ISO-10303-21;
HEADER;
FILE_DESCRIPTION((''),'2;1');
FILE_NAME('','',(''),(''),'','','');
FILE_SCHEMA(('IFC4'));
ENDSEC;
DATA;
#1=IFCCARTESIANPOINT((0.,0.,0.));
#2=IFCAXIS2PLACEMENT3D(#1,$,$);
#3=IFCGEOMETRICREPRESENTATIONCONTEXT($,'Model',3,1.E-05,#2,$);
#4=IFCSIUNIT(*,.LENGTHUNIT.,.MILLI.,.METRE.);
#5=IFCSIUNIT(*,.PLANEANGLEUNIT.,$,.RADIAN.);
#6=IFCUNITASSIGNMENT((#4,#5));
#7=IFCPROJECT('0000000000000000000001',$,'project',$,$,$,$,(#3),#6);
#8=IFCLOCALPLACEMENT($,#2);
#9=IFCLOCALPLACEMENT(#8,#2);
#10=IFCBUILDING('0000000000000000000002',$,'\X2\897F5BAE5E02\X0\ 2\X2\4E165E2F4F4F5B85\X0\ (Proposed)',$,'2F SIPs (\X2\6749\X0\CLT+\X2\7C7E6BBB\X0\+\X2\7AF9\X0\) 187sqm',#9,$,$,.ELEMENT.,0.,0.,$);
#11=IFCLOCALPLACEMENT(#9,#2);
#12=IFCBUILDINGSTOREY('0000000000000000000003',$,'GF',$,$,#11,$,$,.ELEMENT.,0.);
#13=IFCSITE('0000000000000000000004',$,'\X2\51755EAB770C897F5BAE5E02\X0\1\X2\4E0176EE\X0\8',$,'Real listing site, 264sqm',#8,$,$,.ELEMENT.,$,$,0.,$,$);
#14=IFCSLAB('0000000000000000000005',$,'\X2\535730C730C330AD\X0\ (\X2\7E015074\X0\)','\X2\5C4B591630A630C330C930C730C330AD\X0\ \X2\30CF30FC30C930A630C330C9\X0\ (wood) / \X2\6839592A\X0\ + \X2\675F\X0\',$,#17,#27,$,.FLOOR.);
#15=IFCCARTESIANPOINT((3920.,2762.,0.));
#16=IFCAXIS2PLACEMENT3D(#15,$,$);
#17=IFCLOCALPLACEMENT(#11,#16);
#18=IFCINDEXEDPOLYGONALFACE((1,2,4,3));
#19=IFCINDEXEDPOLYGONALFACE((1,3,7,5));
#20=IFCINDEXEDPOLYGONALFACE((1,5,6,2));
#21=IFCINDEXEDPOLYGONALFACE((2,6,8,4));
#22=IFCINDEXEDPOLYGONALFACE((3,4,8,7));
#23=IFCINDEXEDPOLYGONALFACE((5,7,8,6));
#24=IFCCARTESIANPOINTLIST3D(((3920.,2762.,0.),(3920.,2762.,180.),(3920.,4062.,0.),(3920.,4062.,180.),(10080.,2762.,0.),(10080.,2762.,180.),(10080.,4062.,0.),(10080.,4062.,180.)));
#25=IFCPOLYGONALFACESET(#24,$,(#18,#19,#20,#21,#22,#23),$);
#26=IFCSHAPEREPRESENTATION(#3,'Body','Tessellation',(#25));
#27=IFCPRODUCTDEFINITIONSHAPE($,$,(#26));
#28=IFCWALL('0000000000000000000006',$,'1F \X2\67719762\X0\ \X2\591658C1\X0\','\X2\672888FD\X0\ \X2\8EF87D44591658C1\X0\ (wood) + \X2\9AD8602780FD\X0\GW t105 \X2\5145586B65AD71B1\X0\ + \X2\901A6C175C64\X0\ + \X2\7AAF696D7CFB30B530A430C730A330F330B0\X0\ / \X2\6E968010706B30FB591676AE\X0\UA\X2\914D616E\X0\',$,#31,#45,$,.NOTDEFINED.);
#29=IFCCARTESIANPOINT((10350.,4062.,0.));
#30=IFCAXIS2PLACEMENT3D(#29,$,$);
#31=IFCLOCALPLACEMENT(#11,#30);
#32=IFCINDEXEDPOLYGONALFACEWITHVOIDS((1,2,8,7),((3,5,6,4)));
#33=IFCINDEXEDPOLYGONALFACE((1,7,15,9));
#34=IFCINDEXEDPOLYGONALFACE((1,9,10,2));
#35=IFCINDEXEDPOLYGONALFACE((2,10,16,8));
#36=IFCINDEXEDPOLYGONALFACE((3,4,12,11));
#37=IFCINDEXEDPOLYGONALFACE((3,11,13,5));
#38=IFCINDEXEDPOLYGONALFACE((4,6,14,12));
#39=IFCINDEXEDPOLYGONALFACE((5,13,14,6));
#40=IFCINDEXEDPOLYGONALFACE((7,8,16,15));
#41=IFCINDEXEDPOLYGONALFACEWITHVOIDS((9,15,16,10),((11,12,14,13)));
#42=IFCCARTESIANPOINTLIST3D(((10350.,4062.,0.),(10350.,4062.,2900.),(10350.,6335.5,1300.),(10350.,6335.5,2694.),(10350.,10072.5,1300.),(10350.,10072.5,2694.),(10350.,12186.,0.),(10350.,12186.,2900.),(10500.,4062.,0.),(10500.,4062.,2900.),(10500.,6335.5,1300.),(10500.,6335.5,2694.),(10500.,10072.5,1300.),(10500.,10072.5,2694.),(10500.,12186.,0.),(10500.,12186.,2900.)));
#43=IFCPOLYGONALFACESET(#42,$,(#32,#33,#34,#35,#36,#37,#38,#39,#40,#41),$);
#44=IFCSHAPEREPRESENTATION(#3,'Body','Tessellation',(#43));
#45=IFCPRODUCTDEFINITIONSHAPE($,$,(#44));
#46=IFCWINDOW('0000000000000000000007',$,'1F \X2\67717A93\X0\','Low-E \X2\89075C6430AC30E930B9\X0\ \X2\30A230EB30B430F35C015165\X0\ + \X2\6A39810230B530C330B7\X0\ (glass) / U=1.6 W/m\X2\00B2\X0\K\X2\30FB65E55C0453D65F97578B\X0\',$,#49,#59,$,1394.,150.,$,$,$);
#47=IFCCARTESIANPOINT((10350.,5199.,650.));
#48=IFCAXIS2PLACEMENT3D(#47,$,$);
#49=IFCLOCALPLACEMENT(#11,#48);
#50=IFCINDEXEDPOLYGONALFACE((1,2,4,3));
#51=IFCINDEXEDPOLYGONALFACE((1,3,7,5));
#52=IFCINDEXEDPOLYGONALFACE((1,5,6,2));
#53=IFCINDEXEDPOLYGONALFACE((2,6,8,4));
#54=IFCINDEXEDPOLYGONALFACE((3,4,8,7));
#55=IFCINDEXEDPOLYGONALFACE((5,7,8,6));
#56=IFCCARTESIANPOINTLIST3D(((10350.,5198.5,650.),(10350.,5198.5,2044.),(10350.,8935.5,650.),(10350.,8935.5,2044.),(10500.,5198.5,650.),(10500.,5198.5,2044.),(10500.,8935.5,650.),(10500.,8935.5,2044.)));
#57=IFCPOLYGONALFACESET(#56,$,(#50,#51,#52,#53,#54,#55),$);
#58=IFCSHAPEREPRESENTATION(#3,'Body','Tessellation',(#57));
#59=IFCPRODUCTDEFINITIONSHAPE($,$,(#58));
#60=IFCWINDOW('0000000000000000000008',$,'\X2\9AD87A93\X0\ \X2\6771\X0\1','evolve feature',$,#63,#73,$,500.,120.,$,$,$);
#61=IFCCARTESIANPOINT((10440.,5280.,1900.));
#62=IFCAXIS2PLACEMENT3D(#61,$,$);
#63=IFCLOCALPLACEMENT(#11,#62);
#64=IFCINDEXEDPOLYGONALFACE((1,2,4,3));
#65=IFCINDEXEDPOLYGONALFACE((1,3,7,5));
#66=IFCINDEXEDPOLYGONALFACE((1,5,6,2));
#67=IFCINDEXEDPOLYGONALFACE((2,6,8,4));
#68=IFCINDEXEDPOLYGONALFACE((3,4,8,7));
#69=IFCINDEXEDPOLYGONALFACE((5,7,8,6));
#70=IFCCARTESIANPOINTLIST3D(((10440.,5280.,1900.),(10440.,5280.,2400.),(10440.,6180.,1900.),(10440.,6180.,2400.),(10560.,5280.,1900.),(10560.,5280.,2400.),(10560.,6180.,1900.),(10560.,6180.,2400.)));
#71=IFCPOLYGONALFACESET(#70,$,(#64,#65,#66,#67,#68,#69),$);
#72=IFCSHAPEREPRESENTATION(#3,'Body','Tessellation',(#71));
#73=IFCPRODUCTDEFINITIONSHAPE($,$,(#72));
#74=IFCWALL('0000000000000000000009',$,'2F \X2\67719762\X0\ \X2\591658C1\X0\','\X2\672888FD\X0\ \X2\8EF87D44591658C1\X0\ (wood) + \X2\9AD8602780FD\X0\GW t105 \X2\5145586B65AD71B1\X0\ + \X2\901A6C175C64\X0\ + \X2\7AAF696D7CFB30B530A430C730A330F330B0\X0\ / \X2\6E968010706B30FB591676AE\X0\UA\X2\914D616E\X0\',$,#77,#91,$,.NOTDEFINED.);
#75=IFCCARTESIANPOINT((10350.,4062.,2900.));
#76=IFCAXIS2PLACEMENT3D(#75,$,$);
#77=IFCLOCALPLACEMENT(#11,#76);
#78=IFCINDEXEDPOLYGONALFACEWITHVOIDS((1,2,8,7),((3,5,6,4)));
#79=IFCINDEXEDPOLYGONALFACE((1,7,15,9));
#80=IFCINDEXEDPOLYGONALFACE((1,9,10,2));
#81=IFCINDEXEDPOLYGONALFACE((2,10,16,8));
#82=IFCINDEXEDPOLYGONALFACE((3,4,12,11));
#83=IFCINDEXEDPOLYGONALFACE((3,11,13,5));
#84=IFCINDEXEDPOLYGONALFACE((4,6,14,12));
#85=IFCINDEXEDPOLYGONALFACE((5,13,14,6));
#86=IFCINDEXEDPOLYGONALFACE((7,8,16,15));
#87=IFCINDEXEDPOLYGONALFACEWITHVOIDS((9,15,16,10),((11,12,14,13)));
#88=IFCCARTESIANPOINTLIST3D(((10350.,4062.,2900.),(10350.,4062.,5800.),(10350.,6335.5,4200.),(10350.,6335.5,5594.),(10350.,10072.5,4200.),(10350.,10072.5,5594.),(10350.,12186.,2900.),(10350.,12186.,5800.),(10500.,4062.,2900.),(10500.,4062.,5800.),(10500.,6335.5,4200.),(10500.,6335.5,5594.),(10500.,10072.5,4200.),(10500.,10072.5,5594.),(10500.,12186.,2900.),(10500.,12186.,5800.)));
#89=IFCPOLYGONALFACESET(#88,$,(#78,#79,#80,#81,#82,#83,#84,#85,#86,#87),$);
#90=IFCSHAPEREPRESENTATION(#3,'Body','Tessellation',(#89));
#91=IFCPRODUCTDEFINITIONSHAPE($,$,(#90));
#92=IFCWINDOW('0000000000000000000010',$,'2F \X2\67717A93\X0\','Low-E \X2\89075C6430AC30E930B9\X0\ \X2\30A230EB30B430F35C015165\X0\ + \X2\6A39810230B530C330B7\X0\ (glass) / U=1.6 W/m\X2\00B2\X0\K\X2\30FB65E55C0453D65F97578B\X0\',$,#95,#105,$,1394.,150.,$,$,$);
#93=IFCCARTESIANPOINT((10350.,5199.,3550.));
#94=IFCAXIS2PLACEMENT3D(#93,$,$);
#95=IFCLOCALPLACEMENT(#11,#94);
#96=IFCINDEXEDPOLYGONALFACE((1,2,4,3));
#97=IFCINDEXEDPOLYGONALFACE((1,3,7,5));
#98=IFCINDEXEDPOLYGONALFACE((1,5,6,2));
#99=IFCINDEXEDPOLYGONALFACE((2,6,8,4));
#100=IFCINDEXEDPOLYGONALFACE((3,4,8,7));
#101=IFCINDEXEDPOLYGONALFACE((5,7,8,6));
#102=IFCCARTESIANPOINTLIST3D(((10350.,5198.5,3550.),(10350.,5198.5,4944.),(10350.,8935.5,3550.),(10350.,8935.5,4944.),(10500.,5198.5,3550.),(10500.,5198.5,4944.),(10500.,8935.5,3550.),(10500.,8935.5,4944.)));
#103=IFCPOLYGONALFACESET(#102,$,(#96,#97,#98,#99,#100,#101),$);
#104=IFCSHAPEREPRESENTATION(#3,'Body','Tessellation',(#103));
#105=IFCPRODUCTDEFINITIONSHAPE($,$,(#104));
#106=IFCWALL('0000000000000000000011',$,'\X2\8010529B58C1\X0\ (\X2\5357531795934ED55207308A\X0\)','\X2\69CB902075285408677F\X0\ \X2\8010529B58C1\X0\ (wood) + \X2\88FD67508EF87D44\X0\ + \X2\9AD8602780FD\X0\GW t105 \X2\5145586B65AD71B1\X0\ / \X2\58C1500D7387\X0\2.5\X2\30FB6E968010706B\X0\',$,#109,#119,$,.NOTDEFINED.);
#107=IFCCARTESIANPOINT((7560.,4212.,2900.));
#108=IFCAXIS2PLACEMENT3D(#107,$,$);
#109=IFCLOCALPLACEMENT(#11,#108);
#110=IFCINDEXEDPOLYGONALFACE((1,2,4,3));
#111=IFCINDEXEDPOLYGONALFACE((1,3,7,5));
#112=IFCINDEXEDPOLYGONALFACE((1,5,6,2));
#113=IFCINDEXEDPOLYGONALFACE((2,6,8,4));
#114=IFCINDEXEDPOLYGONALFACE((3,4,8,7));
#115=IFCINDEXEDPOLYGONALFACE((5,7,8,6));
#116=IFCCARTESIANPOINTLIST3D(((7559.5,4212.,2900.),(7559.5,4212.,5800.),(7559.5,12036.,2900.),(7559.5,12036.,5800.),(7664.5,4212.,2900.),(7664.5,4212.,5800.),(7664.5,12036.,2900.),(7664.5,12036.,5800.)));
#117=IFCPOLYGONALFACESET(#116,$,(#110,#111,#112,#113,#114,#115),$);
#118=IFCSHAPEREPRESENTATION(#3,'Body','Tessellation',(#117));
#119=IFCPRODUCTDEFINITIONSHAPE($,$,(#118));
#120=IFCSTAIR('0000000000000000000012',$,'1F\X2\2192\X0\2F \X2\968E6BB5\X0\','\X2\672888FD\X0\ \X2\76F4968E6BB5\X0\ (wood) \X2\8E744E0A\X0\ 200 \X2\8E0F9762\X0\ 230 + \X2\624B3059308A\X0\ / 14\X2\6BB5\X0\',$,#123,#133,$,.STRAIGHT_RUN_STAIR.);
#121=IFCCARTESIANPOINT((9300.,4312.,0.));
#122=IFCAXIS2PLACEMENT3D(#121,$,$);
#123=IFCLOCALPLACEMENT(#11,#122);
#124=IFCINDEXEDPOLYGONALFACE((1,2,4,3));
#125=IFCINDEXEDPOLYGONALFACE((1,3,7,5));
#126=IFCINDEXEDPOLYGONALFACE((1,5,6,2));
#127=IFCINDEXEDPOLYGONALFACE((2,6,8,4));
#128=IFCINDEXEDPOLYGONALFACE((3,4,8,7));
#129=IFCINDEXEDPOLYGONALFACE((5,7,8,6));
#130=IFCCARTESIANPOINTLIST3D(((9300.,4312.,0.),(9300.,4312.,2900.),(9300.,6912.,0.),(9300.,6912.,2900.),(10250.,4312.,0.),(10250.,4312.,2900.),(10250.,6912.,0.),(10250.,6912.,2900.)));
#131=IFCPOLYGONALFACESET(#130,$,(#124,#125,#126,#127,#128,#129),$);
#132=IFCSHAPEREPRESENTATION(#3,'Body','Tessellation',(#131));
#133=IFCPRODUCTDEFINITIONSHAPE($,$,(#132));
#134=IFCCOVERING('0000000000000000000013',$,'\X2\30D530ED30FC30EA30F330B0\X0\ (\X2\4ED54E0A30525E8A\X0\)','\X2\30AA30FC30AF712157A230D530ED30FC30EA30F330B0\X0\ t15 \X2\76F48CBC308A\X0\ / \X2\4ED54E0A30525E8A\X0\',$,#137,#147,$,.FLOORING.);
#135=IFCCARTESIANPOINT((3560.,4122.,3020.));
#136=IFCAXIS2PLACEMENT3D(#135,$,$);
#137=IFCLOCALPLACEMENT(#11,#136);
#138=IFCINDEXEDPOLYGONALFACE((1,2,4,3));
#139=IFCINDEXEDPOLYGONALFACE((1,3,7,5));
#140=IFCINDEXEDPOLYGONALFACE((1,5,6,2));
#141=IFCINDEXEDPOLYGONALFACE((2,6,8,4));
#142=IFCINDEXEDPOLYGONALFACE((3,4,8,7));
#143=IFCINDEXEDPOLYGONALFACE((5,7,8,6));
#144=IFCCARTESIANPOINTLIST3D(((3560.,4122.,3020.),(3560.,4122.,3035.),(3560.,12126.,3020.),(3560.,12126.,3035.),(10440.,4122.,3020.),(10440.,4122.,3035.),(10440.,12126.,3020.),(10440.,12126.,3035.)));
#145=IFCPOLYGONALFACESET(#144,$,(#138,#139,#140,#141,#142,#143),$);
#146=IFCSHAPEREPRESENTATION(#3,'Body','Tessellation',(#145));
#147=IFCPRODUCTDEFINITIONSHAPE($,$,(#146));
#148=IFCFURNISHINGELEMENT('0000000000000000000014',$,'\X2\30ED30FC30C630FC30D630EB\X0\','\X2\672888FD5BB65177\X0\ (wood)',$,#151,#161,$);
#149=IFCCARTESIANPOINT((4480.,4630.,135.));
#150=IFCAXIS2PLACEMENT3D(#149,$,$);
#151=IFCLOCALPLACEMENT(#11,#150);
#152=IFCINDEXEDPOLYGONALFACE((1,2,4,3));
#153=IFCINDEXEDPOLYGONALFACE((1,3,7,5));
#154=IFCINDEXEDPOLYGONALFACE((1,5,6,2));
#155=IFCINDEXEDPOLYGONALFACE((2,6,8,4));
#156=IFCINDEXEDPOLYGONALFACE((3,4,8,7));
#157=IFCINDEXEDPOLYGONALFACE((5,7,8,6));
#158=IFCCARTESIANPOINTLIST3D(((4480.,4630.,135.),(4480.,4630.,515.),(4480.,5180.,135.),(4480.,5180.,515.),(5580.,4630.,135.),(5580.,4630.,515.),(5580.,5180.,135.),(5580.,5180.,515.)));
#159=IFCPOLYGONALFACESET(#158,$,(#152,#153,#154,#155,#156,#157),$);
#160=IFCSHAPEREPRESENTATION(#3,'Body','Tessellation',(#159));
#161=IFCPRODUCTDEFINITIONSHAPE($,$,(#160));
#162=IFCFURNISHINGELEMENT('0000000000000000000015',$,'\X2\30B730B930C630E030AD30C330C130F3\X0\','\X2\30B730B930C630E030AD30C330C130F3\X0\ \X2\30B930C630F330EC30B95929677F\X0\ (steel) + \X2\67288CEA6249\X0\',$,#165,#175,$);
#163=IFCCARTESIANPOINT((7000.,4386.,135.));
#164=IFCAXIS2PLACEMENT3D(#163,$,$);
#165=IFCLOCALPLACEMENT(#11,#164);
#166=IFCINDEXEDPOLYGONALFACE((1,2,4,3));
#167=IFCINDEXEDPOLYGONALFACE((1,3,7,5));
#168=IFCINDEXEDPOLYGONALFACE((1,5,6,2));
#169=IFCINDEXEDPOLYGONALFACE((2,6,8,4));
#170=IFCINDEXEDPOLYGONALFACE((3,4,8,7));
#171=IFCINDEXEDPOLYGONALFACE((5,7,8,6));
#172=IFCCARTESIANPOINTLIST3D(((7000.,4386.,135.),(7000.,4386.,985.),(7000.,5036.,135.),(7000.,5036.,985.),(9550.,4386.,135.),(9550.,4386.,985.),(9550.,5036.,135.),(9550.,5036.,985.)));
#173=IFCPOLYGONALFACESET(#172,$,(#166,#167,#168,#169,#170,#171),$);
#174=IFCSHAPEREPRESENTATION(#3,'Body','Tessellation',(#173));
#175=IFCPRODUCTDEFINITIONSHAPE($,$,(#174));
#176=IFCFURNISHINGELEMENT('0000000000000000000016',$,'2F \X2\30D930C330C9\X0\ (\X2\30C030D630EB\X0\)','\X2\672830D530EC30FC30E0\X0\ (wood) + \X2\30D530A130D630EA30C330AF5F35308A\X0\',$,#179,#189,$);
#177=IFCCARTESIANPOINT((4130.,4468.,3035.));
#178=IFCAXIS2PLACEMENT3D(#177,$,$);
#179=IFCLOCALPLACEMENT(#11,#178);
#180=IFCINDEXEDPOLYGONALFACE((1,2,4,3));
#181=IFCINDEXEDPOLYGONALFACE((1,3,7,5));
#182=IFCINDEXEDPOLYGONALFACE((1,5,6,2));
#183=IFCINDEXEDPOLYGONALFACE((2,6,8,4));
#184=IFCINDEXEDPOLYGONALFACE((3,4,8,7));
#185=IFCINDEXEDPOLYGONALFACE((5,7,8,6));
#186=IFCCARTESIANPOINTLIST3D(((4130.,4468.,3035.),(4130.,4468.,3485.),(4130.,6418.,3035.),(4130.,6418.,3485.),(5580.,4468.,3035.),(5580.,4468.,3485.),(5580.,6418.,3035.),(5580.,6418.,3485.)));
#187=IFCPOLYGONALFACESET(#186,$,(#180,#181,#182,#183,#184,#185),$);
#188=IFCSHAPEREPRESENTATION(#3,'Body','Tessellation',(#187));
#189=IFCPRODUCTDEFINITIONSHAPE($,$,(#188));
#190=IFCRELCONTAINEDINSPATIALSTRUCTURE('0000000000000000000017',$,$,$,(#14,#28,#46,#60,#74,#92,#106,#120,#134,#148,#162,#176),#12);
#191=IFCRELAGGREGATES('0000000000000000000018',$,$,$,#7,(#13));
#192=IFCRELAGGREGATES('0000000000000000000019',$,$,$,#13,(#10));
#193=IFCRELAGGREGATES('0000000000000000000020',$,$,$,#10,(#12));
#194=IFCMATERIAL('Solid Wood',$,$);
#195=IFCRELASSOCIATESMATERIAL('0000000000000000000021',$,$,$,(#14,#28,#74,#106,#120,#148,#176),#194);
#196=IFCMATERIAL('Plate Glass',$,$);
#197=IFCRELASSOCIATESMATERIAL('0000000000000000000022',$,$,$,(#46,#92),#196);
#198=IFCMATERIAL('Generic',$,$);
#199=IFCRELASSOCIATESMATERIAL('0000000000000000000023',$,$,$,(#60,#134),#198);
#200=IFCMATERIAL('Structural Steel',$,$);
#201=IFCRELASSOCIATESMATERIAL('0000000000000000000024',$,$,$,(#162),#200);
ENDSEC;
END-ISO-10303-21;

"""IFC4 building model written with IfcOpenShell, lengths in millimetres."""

from ifc_helpers import new_model, si_unit, frame, frame_2d, origin, place, context, project, spatial, rectangle, extrude, material, element, fill, save


model = new_model("IFC4")

# Units and contexts
model_context = context("Model", 3, precision=1e-05, world=origin())
ifc_project = project(units=[si_unit("LENGTHUNIT", "METRE", prefix="MILLI"), si_unit("PLANEANGLEUNIT", "RADIAN")], contexts=[model_context])

# Site, building, storey
site_placement = place(None, origin())
site = spatial("IfcSite", under=ifc_project, at=site_placement, Name="兵庫県西宮市1丁目8", ObjectType="Real listing site, 264sqm", CompositionType="ELEMENT", RefElevation=0.0)
building_placement = place(site_placement, origin())
building = spatial("IfcBuilding", under=site, at=building_placement, Name="西宮市 2世帯住宅 (Proposed)", ObjectType="2F SIPs (杉CLT+籾殻+竹) 187sqm", CompositionType="ELEMENT", ElevationOfRefHeight=0.0, ElevationOfTerrain=0.0)
storey_placement = place(building_placement, origin())
storey = spatial("IfcBuildingStorey", under=building, at=storey_placement, Name="GF", CompositionType="ELEMENT", Elevation=0.0)

# Slab
ifc_material_1 = material(Name="Solid Wood")
slab_placement = place(storey_placement, frame((3920.0, 2762.0, 0.0)))
element("IfcSlab", 1, at=slab_placement, inside=storey, material=ifc_material_1, Name="南デッキ (縁側)", Description="屋外ウッドデッキ ハードウッド (wood) / 根太 + 束", PredefinedType="FLOOR", context=model_context, shape_type="SweptSolid", body=[
    extrude(rectangle(XDim=6160.0, YDim=1300.0, at=frame_2d((3080.0, 650.0))), frame((3920.0, 2762.0, 0.0)), (0.0, 0.0, 1.0), 180.0),
])

# Wall, openings, windows
wall_1_placement = place(storey_placement, frame((10350.0, 4062.0, 0.0)))
wall_1 = element("IfcWall", 2, at=wall_1_placement, inside=storey, material=ifc_material_1, Name="1F 東面 外壁", Description="木製 軸組外壁 (wood) + 高性能GW t105 充填断熱 + 通気層 + 窯業系サイディング / 準耐火・外皮UA配慮", PredefinedType="NOTDEFINED", context=model_context, shape_type="SweptSolid", body=[
    extrude(rectangle(XDim=150.0, YDim=8124.0, at=frame_2d((75.0, 4062.0))), frame((10350.0, 4062.0, 0.0)), (0.0, 0.0, 1.0), 2900.0),
])
opening_1_placement = place(storey_placement, frame((10350.0, 5199.0, 650.0)))
opening_1 = element("IfcOpeningElement", 3, at=opening_1_placement, cuts=wall_1, PredefinedType="NOTDEFINED", context=model_context, shape_type="SweptSolid", body=[
    extrude(rectangle(XDim=150.0, YDim=3737.0, at=frame_2d((75.0, 1868.0))), frame((10350.0, 5199.0, 650.0)), (0.0, 0.0, 1.0), 1394.0),
])
opening_2_placement = place(storey_placement, frame((10440.0, 5280.0, 1900.0)))
opening_2 = element("IfcOpeningElement", 4, at=opening_2_placement, cuts=wall_1, PredefinedType="NOTDEFINED", context=model_context, shape_type="SweptSolid", body=[
    extrude(rectangle(XDim=120.0, YDim=900.0, at=frame_2d((60.0, 450.0))), frame((10440.0, 5280.0, 1900.0)), (0.0, 0.0, 1.0), 500.0),
])
ifc_material_2 = material(Name="Plate Glass")
window_1_placement = place(storey_placement, frame((10350.0, 5199.0, 650.0)))
window_1 = element("IfcWindow", 5, at=window_1_placement, inside=storey, material=ifc_material_2, Name="1F 東窓", Description="Low-E 複層ガラス アルゴン封入 + 樹脂サッシ (glass) / U=1.6 W/m²K・日射取得型", OverallHeight=1394.0, OverallWidth=150.0, context=model_context, shape_type="SweptSolid", body=[
    extrude(rectangle(XDim=150.0, YDim=3737.0, at=frame_2d((75.0, 1868.0))), frame((10350.0, 5199.0, 650.0)), (0.0, 0.0, 1.0), 1394.0),
])
fill(opening_1, window_1)
ifc_material_3 = material(Name="Generic")
window_2_placement = place(storey_placement, frame((10440.0, 5280.0, 1900.0)))
window_2 = element("IfcWindow", 6, at=window_2_placement, inside=storey, material=ifc_material_3, Name="高窓 東1", Description="evolve feature", OverallHeight=500.0, OverallWidth=120.0, context=model_context, shape_type="SweptSolid", body=[
    extrude(rectangle(XDim=120.0, YDim=900.0, at=frame_2d((60.0, 450.0))), frame((10440.0, 5280.0, 1900.0)), (0.0, 0.0, 1.0), 500.0),
])
fill(opening_2, window_2)

# Wall, opening, window
wall_2_placement = place(storey_placement, frame((10350.0, 4062.0, 2900.0)))
wall_2 = element("IfcWall", 7, at=wall_2_placement, inside=storey, material=ifc_material_1, Name="2F 東面 外壁", Description="木製 軸組外壁 (wood) + 高性能GW t105 充填断熱 + 通気層 + 窯業系サイディング / 準耐火・外皮UA配慮", PredefinedType="NOTDEFINED", context=model_context, shape_type="SweptSolid", body=[
    extrude(rectangle(XDim=150.0, YDim=8124.0, at=frame_2d((75.0, 4062.0))), frame((10350.0, 4062.0, 2900.0)), (0.0, 0.0, 1.0), 2900.0),
])
opening_3_placement = place(storey_placement, frame((10350.0, 5199.0, 3550.0)))
opening_3 = element("IfcOpeningElement", 8, at=opening_3_placement, cuts=wall_2, PredefinedType="NOTDEFINED", context=model_context, shape_type="SweptSolid", body=[
    extrude(rectangle(XDim=150.0, YDim=3737.0, at=frame_2d((75.0, 1868.0))), frame((10350.0, 5199.0, 3550.0)), (0.0, 0.0, 1.0), 1394.0),
])
window_3_placement = place(storey_placement, frame((10350.0, 5199.0, 3550.0)))
window_3 = element("IfcWindow", 9, at=window_3_placement, inside=storey, material=ifc_material_2, Name="2F 東窓", Description="Low-E 複層ガラス アルゴン封入 + 樹脂サッシ (glass) / U=1.6 W/m²K・日射取得型", OverallHeight=1394.0, OverallWidth=150.0, context=model_context, shape_type="SweptSolid", body=[
    extrude(rectangle(XDim=150.0, YDim=3737.0, at=frame_2d((75.0, 1868.0))), frame((10350.0, 5199.0, 3550.0)), (0.0, 0.0, 1.0), 1394.0),
])
fill(opening_3, window_3)

# Wall
wall_3_placement = place(storey_placement, frame((7560.0, 4212.0, 2900.0)))
element("IfcWall", 10, at=wall_3_placement, inside=storey, material=ifc_material_1, Name="耐力壁 (南北間仕切り)", Description="構造用合板 耐力壁 (wood) + 製材軸組 + 高性能GW t105 充填断熱 / 壁倍率2.5・準耐火", PredefinedType="NOTDEFINED", context=model_context, shape_type="SweptSolid", body=[
    extrude(rectangle(XDim=105.0, YDim=7824.0, at=frame_2d((52.0, 3912.0))), frame((7560.0, 4212.0, 2900.0)), (0.0, 0.0, 1.0), 2900.0),
])

# Stair
stair_placement = place(storey_placement, frame((9300.0, 4312.0, 0.0)))
element("IfcStair", 11, at=stair_placement, inside=storey, material=ifc_material_1, Name="1F→2F 階段", Description="木製 直階段 (wood) 蹴上 200 踏面 230 + 手すり / 14段", PredefinedType="STRAIGHT_RUN_STAIR", context=model_context, shape_type="SweptSolid", body=[
    extrude(rectangle(XDim=950.0, YDim=2600.0, at=frame_2d((475.0, 1300.0))), frame((9300.0, 4312.0, 0.0)), (0.0, 0.0, 1.0), 2900.0),
])

# Covering
covering_placement = place(storey_placement, frame((3560.0, 4122.0, 3020.0)))
element("IfcCovering", 12, at=covering_placement, inside=storey, material=ifc_material_3, Name="フローリング (仕上げ床)", Description="オーク無垢フローリング t15 直貼り / 仕上げ床", PredefinedType="FLOORING", context=model_context, shape_type="SweptSolid", body=[
    extrude(rectangle(XDim=6880.0, YDim=8004.0, at=frame_2d((3440.0, 4002.0))), frame((3560.0, 4122.0, 3020.0)), (0.0, 0.0, 1.0), 15.0),
])

# Furnishing elements
furnishing_1_placement = place(storey_placement, frame((4480.0, 4630.0, 135.0)))
element("IfcFurnishingElement", 13, at=furnishing_1_placement, inside=storey, material=ifc_material_1, Name="ローテーブル", Description="木製家具 (wood)", context=model_context, shape_type="SweptSolid", body=[
    extrude(rectangle(XDim=1100.0, YDim=550.0, at=frame_2d((550.0, 275.0))), frame((4480.0, 4630.0, 135.0)), (0.0, 0.0, 1.0), 380.0),
])
ifc_material_4 = material(Name="Structural Steel")
furnishing_2_placement = place(storey_placement, frame((7000.0, 4386.0, 135.0)))
element("IfcFurnishingElement", 14, at=furnishing_2_placement, inside=storey, material=ifc_material_4, Name="システムキッチン", Description="システムキッチン ステンレス天板 (steel) + 木質扉", context=model_context, shape_type="SweptSolid", body=[
    extrude(rectangle(XDim=2550.0, YDim=650.0, at=frame_2d((1275.0, 325.0))), frame((7000.0, 4386.0, 135.0)), (0.0, 0.0, 1.0), 850.0),
])
furnishing_3_placement = place(storey_placement, frame((4130.0, 4468.0, 3035.0)))
element("IfcFurnishingElement", 15, at=furnishing_3_placement, inside=storey, material=ifc_material_1, Name="2F ベッド (ダブル)", Description="木フレーム (wood) + ファブリック張り", context=model_context, shape_type="SweptSolid", body=[
    extrude(rectangle(XDim=1450.0, YDim=1950.0, at=frame_2d((725.0, 975.0))), frame((4130.0, 4468.0, 3035.0)), (0.0, 0.0, 1.0), 450.0),
])

save(model, "model.ifc")
